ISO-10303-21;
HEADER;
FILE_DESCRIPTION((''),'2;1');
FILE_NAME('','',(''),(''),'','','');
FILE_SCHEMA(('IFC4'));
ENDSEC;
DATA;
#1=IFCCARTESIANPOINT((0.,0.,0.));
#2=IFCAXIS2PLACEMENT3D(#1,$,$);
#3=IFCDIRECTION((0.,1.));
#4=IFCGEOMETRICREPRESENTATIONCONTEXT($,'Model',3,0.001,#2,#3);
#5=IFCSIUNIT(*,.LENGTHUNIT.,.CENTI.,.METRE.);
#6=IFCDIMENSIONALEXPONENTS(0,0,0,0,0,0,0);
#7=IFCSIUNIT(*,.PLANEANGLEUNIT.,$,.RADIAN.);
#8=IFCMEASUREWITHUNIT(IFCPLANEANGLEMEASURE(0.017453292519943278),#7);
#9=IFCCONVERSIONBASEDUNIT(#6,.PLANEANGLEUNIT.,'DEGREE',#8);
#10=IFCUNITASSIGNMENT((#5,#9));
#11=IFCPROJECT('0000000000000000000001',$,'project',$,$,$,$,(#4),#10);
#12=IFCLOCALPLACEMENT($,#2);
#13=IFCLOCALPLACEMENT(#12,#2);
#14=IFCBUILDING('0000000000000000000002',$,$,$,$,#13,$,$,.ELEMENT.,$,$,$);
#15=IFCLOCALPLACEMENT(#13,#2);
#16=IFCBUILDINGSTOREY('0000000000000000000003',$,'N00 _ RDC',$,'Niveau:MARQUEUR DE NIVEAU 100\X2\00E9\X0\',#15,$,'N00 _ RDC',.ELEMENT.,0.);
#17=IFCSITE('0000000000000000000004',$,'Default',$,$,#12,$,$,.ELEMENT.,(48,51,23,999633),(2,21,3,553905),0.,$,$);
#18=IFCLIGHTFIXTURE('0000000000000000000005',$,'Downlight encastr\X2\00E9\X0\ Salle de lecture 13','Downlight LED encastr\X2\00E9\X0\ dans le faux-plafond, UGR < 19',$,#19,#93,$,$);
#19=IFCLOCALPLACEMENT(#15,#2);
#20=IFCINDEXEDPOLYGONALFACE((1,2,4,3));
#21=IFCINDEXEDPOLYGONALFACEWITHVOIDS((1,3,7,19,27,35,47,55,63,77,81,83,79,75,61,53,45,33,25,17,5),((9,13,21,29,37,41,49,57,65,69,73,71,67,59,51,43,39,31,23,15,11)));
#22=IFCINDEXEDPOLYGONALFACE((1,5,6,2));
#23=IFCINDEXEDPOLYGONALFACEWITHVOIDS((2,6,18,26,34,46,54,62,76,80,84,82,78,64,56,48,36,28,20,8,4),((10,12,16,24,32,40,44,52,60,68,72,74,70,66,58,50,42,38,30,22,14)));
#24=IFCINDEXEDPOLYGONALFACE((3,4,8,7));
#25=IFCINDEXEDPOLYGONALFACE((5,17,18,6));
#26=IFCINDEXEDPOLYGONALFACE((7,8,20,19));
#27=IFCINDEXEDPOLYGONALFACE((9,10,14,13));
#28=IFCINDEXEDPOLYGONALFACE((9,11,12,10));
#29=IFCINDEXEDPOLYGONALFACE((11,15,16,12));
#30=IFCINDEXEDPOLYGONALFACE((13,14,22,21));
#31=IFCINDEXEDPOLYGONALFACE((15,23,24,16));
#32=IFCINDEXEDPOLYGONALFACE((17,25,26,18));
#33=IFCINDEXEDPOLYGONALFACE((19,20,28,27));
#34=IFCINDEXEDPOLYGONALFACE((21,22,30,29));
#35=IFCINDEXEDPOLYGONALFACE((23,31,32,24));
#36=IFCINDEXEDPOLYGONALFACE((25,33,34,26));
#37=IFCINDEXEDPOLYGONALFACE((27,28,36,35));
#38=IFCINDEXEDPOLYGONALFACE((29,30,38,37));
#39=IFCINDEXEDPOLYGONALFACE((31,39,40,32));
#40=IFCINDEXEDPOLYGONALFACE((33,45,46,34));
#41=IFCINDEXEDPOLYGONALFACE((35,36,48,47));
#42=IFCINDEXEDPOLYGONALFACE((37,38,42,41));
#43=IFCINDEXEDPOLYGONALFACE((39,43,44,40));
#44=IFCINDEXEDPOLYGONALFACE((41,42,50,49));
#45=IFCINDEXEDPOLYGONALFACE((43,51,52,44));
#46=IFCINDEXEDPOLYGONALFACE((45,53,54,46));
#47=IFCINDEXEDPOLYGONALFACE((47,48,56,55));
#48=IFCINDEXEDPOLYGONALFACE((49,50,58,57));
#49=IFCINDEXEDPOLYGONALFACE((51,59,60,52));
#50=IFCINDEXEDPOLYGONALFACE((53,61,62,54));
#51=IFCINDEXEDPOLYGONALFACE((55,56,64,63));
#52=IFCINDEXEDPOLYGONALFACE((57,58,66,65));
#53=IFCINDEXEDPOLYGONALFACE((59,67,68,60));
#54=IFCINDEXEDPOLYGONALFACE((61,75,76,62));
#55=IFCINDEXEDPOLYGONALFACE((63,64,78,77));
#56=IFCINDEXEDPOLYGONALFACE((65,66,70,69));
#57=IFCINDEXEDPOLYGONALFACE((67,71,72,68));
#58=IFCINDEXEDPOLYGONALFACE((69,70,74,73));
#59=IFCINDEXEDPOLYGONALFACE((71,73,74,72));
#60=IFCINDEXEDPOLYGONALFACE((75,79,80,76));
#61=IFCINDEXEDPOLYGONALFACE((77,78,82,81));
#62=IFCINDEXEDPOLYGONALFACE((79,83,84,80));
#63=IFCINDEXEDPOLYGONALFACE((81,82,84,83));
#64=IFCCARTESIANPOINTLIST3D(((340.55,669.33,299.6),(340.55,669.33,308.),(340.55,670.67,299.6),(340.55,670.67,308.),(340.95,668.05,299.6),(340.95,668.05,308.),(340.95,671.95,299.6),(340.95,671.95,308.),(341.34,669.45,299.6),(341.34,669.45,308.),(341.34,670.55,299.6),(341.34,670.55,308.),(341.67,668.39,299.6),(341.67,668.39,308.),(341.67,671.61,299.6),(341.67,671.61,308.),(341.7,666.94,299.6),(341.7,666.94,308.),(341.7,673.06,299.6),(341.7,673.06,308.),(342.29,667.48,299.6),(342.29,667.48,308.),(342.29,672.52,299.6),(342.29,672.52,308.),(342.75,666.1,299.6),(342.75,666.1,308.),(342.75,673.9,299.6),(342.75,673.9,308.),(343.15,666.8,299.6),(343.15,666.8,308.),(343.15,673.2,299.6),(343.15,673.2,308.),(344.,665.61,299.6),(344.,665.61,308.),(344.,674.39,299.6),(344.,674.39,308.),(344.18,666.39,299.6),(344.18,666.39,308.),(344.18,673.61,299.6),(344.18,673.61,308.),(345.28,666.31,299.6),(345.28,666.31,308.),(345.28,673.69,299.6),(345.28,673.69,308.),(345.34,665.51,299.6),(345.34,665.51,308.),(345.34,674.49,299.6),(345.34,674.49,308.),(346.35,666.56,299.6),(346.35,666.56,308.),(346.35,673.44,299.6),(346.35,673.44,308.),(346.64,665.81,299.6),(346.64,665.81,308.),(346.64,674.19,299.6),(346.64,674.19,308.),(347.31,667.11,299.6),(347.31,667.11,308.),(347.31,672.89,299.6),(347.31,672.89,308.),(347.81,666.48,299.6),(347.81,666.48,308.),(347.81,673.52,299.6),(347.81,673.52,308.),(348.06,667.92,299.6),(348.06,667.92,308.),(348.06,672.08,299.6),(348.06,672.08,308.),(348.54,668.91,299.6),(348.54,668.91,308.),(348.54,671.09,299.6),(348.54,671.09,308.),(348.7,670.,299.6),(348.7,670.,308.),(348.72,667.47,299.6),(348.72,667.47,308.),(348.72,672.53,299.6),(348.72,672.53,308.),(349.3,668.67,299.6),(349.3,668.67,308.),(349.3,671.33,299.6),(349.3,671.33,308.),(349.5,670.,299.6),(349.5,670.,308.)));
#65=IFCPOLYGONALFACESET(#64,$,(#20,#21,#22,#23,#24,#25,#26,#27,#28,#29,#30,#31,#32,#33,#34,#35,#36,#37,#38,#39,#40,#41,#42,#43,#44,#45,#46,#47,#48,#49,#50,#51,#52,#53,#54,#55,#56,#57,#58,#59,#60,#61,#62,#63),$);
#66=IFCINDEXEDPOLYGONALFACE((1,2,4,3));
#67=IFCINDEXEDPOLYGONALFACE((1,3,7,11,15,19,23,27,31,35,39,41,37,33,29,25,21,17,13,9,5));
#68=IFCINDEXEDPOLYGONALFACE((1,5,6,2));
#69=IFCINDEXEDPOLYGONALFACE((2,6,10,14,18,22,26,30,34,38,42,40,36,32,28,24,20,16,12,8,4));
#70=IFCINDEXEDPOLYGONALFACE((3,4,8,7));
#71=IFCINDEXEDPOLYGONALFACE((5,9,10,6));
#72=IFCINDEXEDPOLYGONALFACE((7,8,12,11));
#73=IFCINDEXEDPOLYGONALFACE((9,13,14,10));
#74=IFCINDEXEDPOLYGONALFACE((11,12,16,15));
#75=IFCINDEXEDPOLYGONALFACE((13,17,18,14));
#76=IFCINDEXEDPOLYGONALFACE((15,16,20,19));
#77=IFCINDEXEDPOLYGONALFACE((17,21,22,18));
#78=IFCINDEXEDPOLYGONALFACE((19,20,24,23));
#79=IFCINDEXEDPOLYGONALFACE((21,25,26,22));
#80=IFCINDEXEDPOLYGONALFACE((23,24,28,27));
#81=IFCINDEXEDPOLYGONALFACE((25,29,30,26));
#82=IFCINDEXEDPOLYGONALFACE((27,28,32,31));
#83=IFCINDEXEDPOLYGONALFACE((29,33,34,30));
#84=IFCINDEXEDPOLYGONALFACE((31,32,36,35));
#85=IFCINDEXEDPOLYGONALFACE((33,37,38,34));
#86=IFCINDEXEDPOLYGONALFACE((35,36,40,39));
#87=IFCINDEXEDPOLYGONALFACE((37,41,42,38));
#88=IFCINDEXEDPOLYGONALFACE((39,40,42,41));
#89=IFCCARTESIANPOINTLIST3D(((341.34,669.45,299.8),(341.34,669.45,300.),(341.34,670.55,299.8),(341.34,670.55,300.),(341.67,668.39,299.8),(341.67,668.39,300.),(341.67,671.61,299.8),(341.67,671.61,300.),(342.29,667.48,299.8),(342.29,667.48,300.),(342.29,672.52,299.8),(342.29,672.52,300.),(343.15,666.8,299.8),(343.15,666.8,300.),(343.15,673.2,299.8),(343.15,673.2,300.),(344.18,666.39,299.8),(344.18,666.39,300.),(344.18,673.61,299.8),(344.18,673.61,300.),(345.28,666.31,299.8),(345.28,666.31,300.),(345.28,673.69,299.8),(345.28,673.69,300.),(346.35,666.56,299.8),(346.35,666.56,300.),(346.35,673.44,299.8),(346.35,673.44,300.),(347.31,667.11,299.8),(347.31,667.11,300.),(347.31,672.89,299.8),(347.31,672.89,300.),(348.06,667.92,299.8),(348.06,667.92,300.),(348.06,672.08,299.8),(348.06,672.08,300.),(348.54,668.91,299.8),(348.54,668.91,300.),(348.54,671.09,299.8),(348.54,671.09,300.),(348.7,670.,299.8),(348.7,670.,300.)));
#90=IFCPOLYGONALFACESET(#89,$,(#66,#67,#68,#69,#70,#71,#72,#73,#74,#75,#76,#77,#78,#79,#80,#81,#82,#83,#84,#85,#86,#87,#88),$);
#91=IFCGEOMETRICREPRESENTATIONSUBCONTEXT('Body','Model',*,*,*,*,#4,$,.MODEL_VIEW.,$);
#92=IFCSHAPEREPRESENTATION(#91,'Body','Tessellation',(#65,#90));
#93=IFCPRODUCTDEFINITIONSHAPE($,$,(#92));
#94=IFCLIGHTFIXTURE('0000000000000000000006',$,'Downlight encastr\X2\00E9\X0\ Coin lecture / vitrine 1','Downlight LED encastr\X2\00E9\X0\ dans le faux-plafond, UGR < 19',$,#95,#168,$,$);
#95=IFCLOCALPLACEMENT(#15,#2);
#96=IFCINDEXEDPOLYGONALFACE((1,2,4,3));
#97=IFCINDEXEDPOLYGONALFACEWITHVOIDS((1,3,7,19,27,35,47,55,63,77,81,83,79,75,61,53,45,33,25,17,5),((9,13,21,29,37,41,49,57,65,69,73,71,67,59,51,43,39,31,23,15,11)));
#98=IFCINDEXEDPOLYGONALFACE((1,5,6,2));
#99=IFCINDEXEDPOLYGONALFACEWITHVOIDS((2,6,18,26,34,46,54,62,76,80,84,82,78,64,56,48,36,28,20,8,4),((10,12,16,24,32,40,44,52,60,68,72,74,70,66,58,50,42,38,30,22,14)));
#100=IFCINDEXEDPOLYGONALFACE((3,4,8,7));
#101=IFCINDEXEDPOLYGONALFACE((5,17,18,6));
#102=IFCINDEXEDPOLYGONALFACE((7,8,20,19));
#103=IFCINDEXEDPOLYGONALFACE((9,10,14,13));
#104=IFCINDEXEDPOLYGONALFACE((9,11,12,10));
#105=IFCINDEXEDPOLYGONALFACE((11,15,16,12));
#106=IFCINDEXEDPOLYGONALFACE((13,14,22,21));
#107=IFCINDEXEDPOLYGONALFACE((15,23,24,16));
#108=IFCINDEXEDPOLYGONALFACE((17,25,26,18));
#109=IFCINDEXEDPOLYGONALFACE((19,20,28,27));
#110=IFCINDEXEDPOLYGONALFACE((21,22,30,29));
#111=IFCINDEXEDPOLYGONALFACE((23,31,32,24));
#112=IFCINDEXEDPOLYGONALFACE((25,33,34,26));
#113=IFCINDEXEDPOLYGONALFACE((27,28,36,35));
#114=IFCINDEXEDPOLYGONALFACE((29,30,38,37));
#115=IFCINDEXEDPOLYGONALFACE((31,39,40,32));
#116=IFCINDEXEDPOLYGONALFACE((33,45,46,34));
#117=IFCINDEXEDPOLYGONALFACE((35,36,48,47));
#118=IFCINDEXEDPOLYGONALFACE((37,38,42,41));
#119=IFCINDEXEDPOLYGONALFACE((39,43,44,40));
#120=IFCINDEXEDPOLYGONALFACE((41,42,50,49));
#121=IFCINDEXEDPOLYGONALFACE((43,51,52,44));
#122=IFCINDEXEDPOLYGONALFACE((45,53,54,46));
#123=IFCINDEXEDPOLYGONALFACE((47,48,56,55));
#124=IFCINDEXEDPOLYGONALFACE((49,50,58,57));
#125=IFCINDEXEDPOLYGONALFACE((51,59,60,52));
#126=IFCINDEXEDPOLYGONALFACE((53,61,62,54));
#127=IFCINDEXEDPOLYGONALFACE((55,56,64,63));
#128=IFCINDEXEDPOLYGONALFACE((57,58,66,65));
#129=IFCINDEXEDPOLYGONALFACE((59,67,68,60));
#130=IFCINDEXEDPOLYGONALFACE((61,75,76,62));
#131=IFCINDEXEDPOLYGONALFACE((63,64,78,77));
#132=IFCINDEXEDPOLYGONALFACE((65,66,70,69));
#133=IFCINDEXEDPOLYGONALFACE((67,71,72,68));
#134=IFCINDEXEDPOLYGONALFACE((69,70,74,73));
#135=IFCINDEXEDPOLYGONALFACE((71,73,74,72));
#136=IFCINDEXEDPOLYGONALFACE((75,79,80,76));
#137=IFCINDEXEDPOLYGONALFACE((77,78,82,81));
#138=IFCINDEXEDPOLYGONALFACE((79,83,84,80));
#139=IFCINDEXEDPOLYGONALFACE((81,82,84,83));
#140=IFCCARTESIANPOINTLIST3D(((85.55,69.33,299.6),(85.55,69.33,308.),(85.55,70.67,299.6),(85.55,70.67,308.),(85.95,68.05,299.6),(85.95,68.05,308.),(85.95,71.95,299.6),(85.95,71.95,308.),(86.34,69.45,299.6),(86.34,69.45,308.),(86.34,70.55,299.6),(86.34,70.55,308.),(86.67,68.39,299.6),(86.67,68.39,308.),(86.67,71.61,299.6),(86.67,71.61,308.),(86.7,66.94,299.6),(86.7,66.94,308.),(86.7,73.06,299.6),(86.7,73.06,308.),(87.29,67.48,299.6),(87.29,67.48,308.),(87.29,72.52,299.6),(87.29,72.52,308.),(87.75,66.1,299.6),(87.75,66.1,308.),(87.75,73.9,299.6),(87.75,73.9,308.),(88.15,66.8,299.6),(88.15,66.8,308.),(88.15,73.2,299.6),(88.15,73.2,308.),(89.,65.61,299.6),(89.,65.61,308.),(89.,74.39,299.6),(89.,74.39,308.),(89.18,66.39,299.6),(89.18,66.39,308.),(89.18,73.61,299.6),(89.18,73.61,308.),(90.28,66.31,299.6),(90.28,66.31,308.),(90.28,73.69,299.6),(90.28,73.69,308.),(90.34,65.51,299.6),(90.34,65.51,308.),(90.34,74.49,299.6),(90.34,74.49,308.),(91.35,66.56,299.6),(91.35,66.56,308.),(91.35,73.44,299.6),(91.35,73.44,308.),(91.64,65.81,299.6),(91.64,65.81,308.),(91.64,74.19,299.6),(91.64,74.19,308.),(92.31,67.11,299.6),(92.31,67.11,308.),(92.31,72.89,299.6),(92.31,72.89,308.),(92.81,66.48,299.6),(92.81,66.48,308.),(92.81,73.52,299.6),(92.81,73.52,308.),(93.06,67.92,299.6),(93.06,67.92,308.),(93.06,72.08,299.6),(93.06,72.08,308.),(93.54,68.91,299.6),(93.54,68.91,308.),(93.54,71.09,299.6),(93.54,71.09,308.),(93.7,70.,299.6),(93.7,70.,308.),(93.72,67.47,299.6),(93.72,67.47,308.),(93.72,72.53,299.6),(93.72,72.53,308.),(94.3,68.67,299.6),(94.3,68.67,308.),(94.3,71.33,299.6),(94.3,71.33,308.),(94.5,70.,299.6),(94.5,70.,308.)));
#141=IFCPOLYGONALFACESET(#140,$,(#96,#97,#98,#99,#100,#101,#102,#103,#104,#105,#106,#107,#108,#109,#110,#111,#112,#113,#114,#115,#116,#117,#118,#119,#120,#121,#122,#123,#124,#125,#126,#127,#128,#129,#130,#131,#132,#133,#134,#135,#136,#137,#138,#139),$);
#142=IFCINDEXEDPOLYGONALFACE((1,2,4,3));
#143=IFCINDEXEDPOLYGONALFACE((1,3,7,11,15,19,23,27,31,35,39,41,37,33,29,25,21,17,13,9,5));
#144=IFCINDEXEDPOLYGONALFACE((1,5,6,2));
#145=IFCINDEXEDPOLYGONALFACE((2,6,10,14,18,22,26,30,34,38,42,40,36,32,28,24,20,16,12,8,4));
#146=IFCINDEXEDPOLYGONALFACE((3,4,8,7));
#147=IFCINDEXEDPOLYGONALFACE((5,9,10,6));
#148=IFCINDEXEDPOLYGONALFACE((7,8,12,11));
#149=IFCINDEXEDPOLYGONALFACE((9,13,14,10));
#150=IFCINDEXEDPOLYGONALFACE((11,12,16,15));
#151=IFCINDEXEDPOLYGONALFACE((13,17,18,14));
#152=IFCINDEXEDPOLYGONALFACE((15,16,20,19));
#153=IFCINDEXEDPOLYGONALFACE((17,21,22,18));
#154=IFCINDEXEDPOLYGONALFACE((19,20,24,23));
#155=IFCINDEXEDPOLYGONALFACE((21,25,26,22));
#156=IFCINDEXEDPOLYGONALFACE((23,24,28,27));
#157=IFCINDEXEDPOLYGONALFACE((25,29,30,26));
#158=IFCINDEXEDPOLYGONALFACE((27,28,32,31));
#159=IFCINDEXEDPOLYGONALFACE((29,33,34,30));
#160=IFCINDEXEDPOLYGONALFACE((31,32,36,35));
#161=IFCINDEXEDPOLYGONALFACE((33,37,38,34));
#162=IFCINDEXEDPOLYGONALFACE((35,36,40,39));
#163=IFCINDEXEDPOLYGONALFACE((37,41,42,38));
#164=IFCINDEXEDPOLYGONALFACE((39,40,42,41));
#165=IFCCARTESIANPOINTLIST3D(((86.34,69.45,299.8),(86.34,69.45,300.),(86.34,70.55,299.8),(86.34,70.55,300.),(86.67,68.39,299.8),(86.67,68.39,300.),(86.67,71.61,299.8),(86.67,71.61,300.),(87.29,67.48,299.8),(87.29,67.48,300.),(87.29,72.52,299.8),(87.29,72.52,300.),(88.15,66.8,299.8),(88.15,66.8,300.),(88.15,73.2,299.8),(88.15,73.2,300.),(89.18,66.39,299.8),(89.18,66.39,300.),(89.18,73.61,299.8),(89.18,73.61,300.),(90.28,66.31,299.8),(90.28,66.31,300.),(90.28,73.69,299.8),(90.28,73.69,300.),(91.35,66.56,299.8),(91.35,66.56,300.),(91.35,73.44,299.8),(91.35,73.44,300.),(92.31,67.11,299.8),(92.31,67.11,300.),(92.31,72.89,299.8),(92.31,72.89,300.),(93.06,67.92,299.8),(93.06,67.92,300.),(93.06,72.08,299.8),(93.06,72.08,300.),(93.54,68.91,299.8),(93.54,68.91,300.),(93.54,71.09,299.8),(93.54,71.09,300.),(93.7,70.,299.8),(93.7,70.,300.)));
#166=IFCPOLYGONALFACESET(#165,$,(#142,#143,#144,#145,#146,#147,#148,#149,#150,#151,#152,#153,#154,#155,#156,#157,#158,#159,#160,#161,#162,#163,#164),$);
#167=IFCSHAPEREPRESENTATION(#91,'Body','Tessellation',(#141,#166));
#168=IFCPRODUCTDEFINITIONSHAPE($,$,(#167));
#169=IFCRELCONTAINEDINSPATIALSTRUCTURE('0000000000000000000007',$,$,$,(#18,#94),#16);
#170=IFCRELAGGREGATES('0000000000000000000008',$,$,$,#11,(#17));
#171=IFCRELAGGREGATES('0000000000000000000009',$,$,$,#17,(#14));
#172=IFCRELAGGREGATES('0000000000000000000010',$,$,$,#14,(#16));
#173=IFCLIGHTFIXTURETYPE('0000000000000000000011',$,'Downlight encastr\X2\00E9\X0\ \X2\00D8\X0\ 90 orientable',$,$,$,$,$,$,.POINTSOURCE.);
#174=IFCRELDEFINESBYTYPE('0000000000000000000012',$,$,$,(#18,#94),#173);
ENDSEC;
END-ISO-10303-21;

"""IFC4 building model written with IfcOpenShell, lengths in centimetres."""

from ifc_helpers import new_model, entity, si_unit, converted_unit, direction, frame, frame_2d, origin, origin_with_axes, place, context, subcontext, project, spatial, circle, hollow_circle, extrude, type_object, element, save


model = new_model("IFC4")

# Units and contexts
model_context = context("Model", 3, precision=0.001, world=origin(), true_north=direction((0.0, 1.0)))
body_context = subcontext(model_context, "Body", "Model", "MODEL_VIEW")
ifc_project = project(units=[si_unit("LENGTHUNIT", "METRE", prefix="CENTI"), converted_unit("PLANEANGLEUNIT", "DEGREE", entity("IfcPlaneAngleMeasure", 0.017453292519943278), si_unit("PLANEANGLEUNIT", "RADIAN"), dimensions=[0, 0, 0, 0, 0, 0, 0])], contexts=[model_context])

# Site, building, storey
site_placement = place(None, origin())
site = spatial("IfcSite", under=ifc_project, at=site_placement, Name="Default", CompositionType="ELEMENT", RefLatitude=(48, 51, 23, 999633), RefLongitude=(2, 21, 3, 553905), RefElevation=0.0)
building_placement = place(site_placement, origin())
building = spatial("IfcBuilding", under=site, at=building_placement, CompositionType="ELEMENT")
storey_placement = place(building_placement, origin())
storey = spatial("IfcBuildingStorey", under=building, at=storey_placement, Name="N00 _ RDC", ObjectType="Niveau:MARQUEUR DE NIVEAU 100é", LongName="N00 _ RDC", CompositionType="ELEMENT", Elevation=0.0)

# Light fixtures
light_fixture_type_1 = type_object("IfcLightFixtureType", Name="Downlight encastré Ø 90 orientable", PredefinedType="POINTSOURCE")
light_fixture_1_placement = place(storey_placement, origin_with_axes())
element("IfcLightFixture", 1, at=light_fixture_1_placement, inside=storey, type_object=light_fixture_type_1, Name="Downlight encastré Salle de lecture 13", Description="Downlight LED encastré dans le faux-plafond, UGR < 19", context=body_context, shape_type="SweptSolid", body=[
    extrude(hollow_circle(Radius=4.5, WallThickness=0.8, at=frame_2d((345.0, 670.0))), frame((0.0, 0.0, 299.6)), (0.0, 0.0, 1.0), 8.4),
    extrude(circle(Radius=3.7, at=frame_2d((345.0, 670.0))), frame((0.0, 0.0, 299.8)), (0.0, 0.0, 1.0), 0.2),
])
light_fixture_2_placement = place(storey_placement, origin_with_axes())
element("IfcLightFixture", 2, at=light_fixture_2_placement, inside=storey, type_object=light_fixture_type_1, Name="Downlight encastré Coin lecture / vitrine 1", Description="Downlight LED encastré dans le faux-plafond, UGR < 19", context=body_context, shape_type="SweptSolid", body=[
    extrude(hollow_circle(Radius=4.5, WallThickness=0.8, at=frame_2d((90.0, 70.0))), frame((0.0, 0.0, 299.6)), (0.0, 0.0, 1.0), 8.4),
    extrude(circle(Radius=3.7, at=frame_2d((90.0, 70.0))), frame((0.0, 0.0, 299.8)), (0.0, 0.0, 1.0), 0.2),
])

save(model, "model.ifc")
